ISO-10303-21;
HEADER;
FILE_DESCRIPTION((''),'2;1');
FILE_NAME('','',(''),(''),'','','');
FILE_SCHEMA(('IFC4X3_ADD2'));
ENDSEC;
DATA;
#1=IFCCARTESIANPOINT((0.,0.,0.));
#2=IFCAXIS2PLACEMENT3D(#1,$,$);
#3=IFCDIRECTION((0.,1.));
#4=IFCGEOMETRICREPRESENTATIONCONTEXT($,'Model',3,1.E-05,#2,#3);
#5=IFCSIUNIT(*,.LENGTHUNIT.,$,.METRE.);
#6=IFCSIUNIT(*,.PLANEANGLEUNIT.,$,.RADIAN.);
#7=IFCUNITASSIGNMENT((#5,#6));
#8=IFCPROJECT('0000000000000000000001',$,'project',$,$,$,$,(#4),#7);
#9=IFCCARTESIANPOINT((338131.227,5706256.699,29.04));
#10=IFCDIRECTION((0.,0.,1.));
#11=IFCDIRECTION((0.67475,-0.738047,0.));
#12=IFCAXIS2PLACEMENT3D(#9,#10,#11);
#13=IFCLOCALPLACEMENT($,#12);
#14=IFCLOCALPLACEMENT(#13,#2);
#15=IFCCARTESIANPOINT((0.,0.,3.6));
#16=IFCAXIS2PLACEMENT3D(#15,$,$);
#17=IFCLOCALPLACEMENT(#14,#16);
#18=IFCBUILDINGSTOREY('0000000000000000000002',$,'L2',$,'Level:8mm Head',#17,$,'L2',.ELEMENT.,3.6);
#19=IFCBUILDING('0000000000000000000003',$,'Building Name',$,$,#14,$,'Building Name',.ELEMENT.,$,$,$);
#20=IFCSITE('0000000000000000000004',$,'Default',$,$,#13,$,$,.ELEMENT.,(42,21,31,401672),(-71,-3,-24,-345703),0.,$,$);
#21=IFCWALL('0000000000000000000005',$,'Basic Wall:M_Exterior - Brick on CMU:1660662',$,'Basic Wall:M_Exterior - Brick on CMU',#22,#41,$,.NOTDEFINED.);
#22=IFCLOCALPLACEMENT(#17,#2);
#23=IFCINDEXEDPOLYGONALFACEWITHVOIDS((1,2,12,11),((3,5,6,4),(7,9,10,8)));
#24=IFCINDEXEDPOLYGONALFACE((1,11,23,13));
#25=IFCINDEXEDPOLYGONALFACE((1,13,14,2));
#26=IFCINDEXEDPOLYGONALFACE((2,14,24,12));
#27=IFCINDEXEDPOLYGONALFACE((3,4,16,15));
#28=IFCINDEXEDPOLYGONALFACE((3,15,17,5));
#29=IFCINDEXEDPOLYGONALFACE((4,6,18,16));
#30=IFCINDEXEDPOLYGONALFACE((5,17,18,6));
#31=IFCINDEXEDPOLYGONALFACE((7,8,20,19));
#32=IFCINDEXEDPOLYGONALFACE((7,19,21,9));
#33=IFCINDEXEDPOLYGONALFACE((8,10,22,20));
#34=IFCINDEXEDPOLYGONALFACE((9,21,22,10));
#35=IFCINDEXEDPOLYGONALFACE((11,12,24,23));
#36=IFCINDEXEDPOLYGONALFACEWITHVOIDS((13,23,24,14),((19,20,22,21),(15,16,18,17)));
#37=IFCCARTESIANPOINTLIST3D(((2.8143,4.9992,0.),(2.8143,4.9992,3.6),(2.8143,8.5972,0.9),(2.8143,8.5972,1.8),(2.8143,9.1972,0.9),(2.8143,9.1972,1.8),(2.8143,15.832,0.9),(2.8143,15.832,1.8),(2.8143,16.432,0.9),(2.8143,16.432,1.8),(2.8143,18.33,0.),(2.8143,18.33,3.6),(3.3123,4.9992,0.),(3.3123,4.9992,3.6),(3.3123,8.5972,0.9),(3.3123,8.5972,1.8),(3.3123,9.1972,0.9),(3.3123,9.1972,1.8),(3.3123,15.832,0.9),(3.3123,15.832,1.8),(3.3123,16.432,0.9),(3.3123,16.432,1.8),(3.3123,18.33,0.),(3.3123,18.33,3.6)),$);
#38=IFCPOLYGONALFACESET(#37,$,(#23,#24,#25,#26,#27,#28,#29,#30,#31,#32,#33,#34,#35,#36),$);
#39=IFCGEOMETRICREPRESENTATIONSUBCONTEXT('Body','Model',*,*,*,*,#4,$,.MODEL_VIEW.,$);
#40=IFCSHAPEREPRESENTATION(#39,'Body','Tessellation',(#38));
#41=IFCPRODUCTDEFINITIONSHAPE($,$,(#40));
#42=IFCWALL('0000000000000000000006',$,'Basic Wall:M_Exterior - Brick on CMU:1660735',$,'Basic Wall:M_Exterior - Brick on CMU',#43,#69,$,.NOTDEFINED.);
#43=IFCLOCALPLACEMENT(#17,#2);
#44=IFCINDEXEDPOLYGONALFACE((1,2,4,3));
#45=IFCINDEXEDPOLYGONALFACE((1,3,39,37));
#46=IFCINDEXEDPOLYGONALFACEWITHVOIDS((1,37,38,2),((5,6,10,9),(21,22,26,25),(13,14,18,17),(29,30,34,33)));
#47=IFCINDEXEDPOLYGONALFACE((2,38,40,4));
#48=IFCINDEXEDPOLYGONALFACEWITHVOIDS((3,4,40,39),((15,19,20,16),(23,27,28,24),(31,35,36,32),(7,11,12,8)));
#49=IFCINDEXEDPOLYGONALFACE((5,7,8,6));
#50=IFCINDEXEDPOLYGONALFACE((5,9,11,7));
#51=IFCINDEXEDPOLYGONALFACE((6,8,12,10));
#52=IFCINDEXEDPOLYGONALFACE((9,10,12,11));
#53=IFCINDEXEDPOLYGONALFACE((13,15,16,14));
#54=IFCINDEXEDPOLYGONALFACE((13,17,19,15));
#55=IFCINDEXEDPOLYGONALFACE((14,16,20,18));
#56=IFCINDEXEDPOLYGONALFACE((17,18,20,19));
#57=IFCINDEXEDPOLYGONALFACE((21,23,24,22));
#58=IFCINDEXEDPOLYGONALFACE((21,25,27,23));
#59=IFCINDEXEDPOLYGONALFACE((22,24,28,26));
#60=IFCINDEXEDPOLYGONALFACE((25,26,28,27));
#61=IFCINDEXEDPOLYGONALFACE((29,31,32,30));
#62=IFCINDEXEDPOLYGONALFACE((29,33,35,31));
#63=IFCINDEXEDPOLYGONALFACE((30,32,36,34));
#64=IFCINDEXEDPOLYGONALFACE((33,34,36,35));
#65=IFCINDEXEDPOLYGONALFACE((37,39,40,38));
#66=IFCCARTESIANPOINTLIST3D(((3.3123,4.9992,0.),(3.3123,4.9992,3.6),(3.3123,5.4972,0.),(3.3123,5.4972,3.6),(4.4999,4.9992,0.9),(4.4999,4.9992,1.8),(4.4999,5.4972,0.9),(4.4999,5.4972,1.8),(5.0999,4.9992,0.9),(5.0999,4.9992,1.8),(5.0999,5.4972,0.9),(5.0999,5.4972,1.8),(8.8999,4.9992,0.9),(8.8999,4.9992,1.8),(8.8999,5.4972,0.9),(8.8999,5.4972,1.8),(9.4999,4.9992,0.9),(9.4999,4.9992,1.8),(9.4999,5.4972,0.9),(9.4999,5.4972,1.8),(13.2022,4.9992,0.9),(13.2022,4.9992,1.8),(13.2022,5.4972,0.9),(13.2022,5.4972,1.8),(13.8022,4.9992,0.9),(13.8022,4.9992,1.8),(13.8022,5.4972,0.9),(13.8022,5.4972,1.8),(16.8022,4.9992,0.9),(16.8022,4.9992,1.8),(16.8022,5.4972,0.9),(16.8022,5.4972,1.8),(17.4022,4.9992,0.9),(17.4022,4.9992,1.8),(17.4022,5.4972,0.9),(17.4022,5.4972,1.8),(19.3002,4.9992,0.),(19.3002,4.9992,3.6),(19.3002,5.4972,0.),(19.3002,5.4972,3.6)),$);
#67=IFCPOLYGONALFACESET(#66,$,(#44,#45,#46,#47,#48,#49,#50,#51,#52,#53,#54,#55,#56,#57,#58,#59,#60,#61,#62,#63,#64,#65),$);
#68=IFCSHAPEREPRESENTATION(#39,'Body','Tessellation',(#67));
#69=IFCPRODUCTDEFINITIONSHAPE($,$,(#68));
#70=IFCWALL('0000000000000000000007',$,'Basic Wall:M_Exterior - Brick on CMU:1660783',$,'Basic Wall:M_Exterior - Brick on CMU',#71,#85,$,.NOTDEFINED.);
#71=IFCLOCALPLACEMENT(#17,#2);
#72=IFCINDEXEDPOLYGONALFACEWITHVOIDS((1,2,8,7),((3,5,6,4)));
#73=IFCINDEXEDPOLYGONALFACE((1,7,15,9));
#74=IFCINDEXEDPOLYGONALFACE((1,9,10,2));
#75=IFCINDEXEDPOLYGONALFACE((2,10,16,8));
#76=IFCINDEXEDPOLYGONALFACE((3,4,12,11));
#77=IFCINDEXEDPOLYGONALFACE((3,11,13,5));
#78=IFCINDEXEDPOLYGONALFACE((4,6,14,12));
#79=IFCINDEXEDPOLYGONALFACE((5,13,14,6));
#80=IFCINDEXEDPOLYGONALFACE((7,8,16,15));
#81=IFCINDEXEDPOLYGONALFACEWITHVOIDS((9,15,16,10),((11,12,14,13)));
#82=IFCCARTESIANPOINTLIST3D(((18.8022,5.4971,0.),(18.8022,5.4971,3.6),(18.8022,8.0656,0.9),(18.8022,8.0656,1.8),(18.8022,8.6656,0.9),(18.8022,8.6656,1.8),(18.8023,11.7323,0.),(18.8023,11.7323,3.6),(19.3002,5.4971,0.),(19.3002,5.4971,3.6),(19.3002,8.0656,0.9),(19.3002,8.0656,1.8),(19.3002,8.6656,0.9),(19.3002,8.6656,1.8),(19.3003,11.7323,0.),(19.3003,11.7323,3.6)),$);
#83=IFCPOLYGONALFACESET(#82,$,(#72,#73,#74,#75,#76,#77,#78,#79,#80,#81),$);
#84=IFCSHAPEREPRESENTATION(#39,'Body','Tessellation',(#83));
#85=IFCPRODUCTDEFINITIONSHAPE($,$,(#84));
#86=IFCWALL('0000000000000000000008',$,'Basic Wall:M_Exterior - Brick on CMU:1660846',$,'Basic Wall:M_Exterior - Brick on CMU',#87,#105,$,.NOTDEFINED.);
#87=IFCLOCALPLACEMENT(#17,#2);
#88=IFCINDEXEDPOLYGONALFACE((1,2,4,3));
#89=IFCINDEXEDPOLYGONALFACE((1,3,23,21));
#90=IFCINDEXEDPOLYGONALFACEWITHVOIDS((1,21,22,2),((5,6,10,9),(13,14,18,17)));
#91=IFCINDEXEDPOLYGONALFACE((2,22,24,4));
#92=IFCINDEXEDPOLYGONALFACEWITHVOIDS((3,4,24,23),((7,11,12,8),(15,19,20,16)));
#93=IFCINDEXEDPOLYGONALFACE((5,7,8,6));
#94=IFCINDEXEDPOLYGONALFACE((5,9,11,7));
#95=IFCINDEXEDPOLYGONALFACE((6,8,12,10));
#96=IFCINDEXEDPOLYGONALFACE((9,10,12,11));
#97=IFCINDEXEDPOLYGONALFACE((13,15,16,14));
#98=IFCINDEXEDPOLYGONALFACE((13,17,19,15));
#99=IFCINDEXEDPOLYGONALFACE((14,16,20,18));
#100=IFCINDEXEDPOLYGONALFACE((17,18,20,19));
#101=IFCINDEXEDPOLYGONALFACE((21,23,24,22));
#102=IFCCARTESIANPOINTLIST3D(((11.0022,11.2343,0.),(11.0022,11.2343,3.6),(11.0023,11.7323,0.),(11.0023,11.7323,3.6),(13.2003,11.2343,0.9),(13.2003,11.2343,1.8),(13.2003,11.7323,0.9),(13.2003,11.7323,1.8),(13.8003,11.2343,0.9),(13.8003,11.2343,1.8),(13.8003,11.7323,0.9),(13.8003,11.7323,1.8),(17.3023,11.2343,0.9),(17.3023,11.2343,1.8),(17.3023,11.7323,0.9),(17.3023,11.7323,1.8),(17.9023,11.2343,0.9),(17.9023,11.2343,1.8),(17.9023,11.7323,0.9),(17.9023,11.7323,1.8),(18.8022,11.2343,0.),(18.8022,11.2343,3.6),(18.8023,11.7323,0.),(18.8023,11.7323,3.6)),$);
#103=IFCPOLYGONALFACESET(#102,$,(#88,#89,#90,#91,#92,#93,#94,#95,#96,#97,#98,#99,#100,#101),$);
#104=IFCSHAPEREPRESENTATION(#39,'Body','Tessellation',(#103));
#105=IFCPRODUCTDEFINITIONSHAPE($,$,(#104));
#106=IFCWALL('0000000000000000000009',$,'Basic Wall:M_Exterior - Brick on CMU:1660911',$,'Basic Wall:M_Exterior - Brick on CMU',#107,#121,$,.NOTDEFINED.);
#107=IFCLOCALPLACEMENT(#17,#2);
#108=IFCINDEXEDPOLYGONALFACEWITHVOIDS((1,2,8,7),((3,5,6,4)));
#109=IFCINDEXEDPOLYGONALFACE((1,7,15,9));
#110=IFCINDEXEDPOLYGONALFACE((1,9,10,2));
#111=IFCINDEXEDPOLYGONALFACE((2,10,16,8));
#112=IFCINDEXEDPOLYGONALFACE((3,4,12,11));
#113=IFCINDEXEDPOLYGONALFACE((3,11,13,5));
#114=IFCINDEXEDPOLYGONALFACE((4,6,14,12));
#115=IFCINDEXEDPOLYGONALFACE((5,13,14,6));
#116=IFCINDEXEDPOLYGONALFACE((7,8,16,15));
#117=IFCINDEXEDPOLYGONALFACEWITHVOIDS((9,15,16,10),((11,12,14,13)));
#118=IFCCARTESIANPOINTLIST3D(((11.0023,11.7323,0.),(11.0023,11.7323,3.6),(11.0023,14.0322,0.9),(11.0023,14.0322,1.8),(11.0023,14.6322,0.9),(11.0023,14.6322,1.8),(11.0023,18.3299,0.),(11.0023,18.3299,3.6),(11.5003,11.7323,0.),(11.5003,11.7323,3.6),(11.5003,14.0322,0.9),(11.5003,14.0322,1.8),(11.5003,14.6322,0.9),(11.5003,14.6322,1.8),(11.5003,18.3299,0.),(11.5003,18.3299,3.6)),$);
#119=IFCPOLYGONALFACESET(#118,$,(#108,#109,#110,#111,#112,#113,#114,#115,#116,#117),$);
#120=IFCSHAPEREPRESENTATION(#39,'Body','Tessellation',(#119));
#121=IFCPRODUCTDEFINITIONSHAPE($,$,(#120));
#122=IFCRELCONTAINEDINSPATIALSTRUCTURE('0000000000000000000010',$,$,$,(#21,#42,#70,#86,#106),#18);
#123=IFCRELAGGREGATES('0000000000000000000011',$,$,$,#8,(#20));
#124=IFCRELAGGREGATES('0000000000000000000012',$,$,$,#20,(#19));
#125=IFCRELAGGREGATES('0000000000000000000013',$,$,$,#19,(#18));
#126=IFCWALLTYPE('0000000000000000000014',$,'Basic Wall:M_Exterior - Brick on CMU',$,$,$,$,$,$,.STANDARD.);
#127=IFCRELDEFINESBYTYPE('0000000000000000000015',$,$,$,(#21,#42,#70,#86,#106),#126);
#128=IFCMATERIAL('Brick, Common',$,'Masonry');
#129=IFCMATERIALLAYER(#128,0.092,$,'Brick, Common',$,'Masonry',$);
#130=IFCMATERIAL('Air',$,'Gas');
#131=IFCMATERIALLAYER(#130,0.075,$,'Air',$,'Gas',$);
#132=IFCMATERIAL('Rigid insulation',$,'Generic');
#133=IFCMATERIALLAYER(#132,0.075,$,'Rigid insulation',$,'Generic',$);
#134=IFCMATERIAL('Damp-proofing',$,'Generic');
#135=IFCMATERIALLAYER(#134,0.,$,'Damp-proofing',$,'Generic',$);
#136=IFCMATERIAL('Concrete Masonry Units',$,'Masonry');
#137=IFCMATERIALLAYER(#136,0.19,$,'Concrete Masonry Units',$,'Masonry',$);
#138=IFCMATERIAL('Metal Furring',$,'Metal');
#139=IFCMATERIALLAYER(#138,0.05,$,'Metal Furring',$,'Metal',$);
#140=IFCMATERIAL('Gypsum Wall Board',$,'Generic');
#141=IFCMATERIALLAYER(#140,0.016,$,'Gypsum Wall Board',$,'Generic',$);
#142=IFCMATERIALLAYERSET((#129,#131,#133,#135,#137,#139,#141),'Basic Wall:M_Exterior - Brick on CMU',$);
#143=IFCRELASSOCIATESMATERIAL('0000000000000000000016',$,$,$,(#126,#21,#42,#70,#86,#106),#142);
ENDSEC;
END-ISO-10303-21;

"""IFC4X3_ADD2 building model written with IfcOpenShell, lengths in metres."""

from ifc_helpers import new_model, si_unit, direction, frame, frame_2d, origin, place, context, subcontext, project, spatial, rectangle, extrude, material, layer, layer_set, type_object, element, save


model = new_model("IFC4X3_ADD2")

# Units and contexts
model_context = context("Model", 3, precision=1e-05, world=origin(), true_north=direction((0.0, 1.0)))
body_context = subcontext(model_context, "Body", "Model", "MODEL_VIEW")
ifc_project = project(units=[si_unit("LENGTHUNIT", "METRE"), si_unit("PLANEANGLEUNIT", "RADIAN")], contexts=[model_context])

# Site, building, storey
site_placement = place(None, frame((338131.227, 5706256.699, 29.04), z_axis=(0.0, 0.0, 1.0), x_axis=(0.67475, -0.738047, 0.0)))
site = spatial("IfcSite", under=ifc_project, at=site_placement, Name="Default", CompositionType="ELEMENT", RefLatitude=(42, 21, 31, 401672), RefLongitude=(-71, -3, -24, -345703), RefElevation=0.0)
building_placement = place(site_placement, origin())
building = spatial("IfcBuilding", under=site, at=building_placement, Name="Building Name", LongName="Building Name", CompositionType="ELEMENT")
storey_placement = place(building_placement, frame((0.0, 0.0, 3.6)))
storey = spatial("IfcBuildingStorey", under=building, at=storey_placement, Name="L2", ObjectType="Level:8mm Head", LongName="L2", CompositionType="ELEMENT", Elevation=3.6)

# Walls, openings
ifc_material_1 = material(Name="Brick, Common", Category="Masonry")
ifc_layer_1 = layer(ifc_material_1, 0.092, Name="Brick, Common", Category="Masonry")
ifc_material_2 = material(Name="Air", Category="Gas")
ifc_layer_2 = layer(ifc_material_2, 0.075, Name="Air", Category="Gas")
ifc_material_3 = material(Name="Rigid insulation", Category="Generic")
ifc_layer_3 = layer(ifc_material_3, 0.075, Name="Rigid insulation", Category="Generic")
ifc_material_4 = material(Name="Damp-proofing", Category="Generic")
ifc_layer_4 = layer(ifc_material_4, 0.0, Name="Damp-proofing", Category="Generic")
ifc_material_5 = material(Name="Concrete Masonry Units", Category="Masonry")
ifc_layer_5 = layer(ifc_material_5, 0.19, Name="Concrete Masonry Units", Category="Masonry")
ifc_material_6 = material(Name="Metal Furring", Category="Metal")
ifc_layer_6 = layer(ifc_material_6, 0.05, Name="Metal Furring", Category="Metal")
ifc_material_7 = material(Name="Gypsum Wall Board", Category="Generic")
ifc_layer_7 = layer(ifc_material_7, 0.016, Name="Gypsum Wall Board", Category="Generic")
ifc_layer_set = layer_set([ifc_layer_1, ifc_layer_2, ifc_layer_3, ifc_layer_4, ifc_layer_5, ifc_layer_6, ifc_layer_7], Name="Basic Wall:M_Exterior - Brick on CMU")
wall_type = type_object("IfcWallType", Name="Basic Wall:M_Exterior - Brick on CMU", PredefinedType="STANDARD", material=ifc_layer_set)
wall_1_placement = place(storey_placement, frame((3.0633, 18.33, 0.0), z_axis=(0.0, 0.0, 1.0), x_axis=(-0.000006, -1.0, 0.0)))
wall_1 = element("IfcWall", 1, at=wall_1_placement, inside=storey, type_object=wall_type, material=ifc_layer_set, Name="Basic Wall:M_Exterior - Brick on CMU:1660662", ObjectType="Basic Wall:M_Exterior - Brick on CMU", PredefinedType="NOTDEFINED", context=body_context, shape_type="SweptSolid", body=[
    extrude(rectangle(XDim=13.3308, YDim=0.498, at=frame_2d((6.6654, 0.0), x_axis=(-1.0, 0.0))), origin(), (0.0, 0.0, 1.0), 3.6),
])
opening_1_placement = place(wall_1_placement, frame((18.33, -3.0631, 0.9)))
element("IfcOpeningElement", 2, at=opening_1_placement, cuts=wall_1, PredefinedType="OPENING", context=body_context, shape_type="SweptSolid", body=[
    extrude(rectangle(XDim=0.9, YDim=0.6, at=frame_2d((0.0, 0.0), x_axis=(0.0, 1.0))), frame((-16.132, 1.7882, 0.45), z_axis=(0.0, 1.0, 0.0), x_axis=(1.0, 0.0, 0.0)), (0.0, 0.0, 1.0), 3.048),
])
opening_2_placement = place(wall_1_placement, frame((18.33, -3.0631, 0.9)))
element("IfcOpeningElement", 3, at=opening_2_placement, cuts=wall_1, PredefinedType="OPENING", context=body_context, shape_type="SweptSolid", body=[
    extrude(rectangle(XDim=0.9, YDim=0.6, at=frame_2d((0.0, 0.0), x_axis=(0.0, 1.0))), frame((-8.8972, 1.7882, 0.45), z_axis=(0.0, 1.0, 0.0), x_axis=(1.0, 0.0, 0.0)), (0.0, 0.0, 1.0), 3.048),
])
wall_2_placement = place(storey_placement, frame((3.3123, 5.2482, 0.0)))
wall_2 = element("IfcWall", 4, at=wall_2_placement, inside=storey, type_object=wall_type, material=ifc_layer_set, Name="Basic Wall:M_Exterior - Brick on CMU:1660735", ObjectType="Basic Wall:M_Exterior - Brick on CMU", PredefinedType="NOTDEFINED", context=body_context, shape_type="SweptSolid", body=[
    extrude(rectangle(XDim=15.988, YDim=0.498, at=frame_2d((7.994, 0.0), x_axis=(-1.0, 0.0))), origin(), (0.0, 0.0, 1.0), 3.6),
])
opening_3_placement = place(wall_2_placement, frame((-3.3122, -5.2482, 0.9)))
element("IfcOpeningElement", 5, at=opening_3_placement, cuts=wall_2, PredefinedType="OPENING", context=body_context, shape_type="SweptSolid", body=[
    extrude(rectangle(XDim=0.9, YDim=0.6, at=frame_2d((0.0, 0.0), x_axis=(0.0, 1.0))), frame((9.1999, 3.9732, 0.45), z_axis=(0.0, 1.0, 0.0), x_axis=(1.0, 0.0, 0.0)), (0.0, 0.0, 1.0), 3.048),
])
opening_4_placement = place(wall_2_placement, frame((-3.3122, -5.2482, 0.9)))
element("IfcOpeningElement", 6, at=opening_4_placement, cuts=wall_2, PredefinedType="OPENING", context=body_context, shape_type="SweptSolid", body=[
    extrude(rectangle(XDim=0.9, YDim=0.6, at=frame_2d((0.0, 0.0), x_axis=(0.0, 1.0))), frame((4.7999, 3.9732, 0.45), z_axis=(0.0, 1.0, 0.0), x_axis=(1.0, 0.0, 0.0)), (0.0, 0.0, 1.0), 3.048),
])
opening_5_placement = place(wall_2_placement, frame((-3.3122, -5.2482, 0.9)))
element("IfcOpeningElement", 7, at=opening_5_placement, cuts=wall_2, PredefinedType="OPENING", context=body_context, shape_type="SweptSolid", body=[
    extrude(rectangle(XDim=0.9, YDim=0.6, at=frame_2d((0.0, 0.0), x_axis=(0.0, 1.0))), frame((17.1022, 3.9732, 0.45), z_axis=(0.0, 1.0, 0.0), x_axis=(1.0, 0.0, 0.0)), (0.0, 0.0, 1.0), 3.048),
])
opening_6_placement = place(wall_2_placement, frame((-3.3122, -5.2482, 0.9)))
element("IfcOpeningElement", 8, at=opening_6_placement, cuts=wall_2, PredefinedType="OPENING", context=body_context, shape_type="SweptSolid", body=[
    extrude(rectangle(XDim=0.9, YDim=0.6, at=frame_2d((0.0, 0.0), x_axis=(0.0, 1.0))), frame((13.5022, 3.9732, 0.45), z_axis=(0.0, 1.0, 0.0), x_axis=(1.0, 0.0, 0.0)), (0.0, 0.0, 1.0), 3.048),
])

# Wall, opening
wall_3_placement = place(storey_placement, frame((19.0512, 5.4971, 0.0), z_axis=(0.0, 0.0, 1.0), x_axis=(0.000006, 1.0, 0.0)))
wall_3 = element("IfcWall", 9, at=wall_3_placement, inside=storey, type_object=wall_type, material=ifc_layer_set, Name="Basic Wall:M_Exterior - Brick on CMU:1660783", ObjectType="Basic Wall:M_Exterior - Brick on CMU", PredefinedType="NOTDEFINED", context=body_context, shape_type="SweptSolid", body=[
    extrude(rectangle(XDim=6.2351, YDim=0.498, at=frame_2d((3.1176, 0.0), x_axis=(-1.0, 0.0))), origin(), (0.0, 0.0, 1.0), 3.6),
])
opening_7_placement = place(wall_3_placement, frame((-5.4974, 19.0511, 0.9)))
element("IfcOpeningElement", 10, at=opening_7_placement, cuts=wall_3, PredefinedType="OPENING", context=body_context, shape_type="SweptSolid", body=[
    extrude(rectangle(XDim=0.9, YDim=0.6, at=frame_2d((0.0, 0.0), x_axis=(0.0, 1.0))), frame((8.3658, -20.3262, 0.45), z_axis=(0.0, 1.0, 0.0), x_axis=(1.0, 0.0, 0.0)), (0.0, 0.0, 1.0), 3.048),
])

# Wall, openings
wall_4_placement = place(storey_placement, frame((18.8023, 11.4833, 0.0), z_axis=(0.0, 0.0, 1.0), x_axis=(-1.0, 0.000006, 0.0)))
wall_4 = element("IfcWall", 11, at=wall_4_placement, inside=storey, type_object=wall_type, material=ifc_layer_set, Name="Basic Wall:M_Exterior - Brick on CMU:1660846", ObjectType="Basic Wall:M_Exterior - Brick on CMU", PredefinedType="NOTDEFINED", context=body_context, shape_type="SweptSolid", body=[
    extrude(rectangle(XDim=7.8, YDim=0.498, at=frame_2d((3.9, 0.0), x_axis=(-1.0, 0.0))), origin(), (0.0, 0.0, 1.0), 3.6),
])
opening_8_placement = place(wall_4_placement, frame((18.8021, 11.4835, 0.9)))
element("IfcOpeningElement", 12, at=opening_8_placement, cuts=wall_4, PredefinedType="OPENING", context=body_context, shape_type="SweptSolid", body=[
    extrude(rectangle(XDim=0.9, YDim=0.6, at=frame_2d((0.0, 0.0), x_axis=(0.0, 1.0))), frame((-13.5002, -12.7584, 0.45), z_axis=(0.0, 1.0, 0.0), x_axis=(1.0, 0.0, 0.0)), (0.0, 0.0, 1.0), 3.048),
])
opening_9_placement = place(wall_4_placement, frame((18.8021, 11.4835, 0.9)))
element("IfcOpeningElement", 13, at=opening_9_placement, cuts=wall_4, PredefinedType="OPENING", context=body_context, shape_type="SweptSolid", body=[
    extrude(rectangle(XDim=0.9, YDim=0.6, at=frame_2d((0.0, 0.0), x_axis=(0.0, 1.0))), frame((-17.6022, -12.7584, 0.45), z_axis=(0.0, 1.0, 0.0), x_axis=(1.0, 0.0, 0.0)), (0.0, 0.0, 1.0), 3.048),
])

# Wall, opening
wall_5_placement = place(storey_placement, frame((11.2513, 11.7323, 0.0), z_axis=(0.0, 0.0, 1.0), x_axis=(0.000006, 1.0, 0.0)))
wall_5 = element("IfcWall", 14, at=wall_5_placement, inside=storey, type_object=wall_type, material=ifc_layer_set, Name="Basic Wall:M_Exterior - Brick on CMU:1660911", ObjectType="Basic Wall:M_Exterior - Brick on CMU", PredefinedType="NOTDEFINED", context=body_context, shape_type="SweptSolid", body=[
    extrude(rectangle(XDim=6.5976, YDim=0.498, at=frame_2d((3.2988, 0.0), x_axis=(-1.0, 0.0))), origin(), (0.0, 0.0, 1.0), 3.6),
])
opening_10_placement = place(wall_5_placement, frame((-11.7325, 11.2511, 0.9)))
element("IfcOpeningElement", 15, at=opening_10_placement, cuts=wall_5, PredefinedType="OPENING", context=body_context, shape_type="SweptSolid", body=[
    extrude(rectangle(XDim=0.9, YDim=0.6, at=frame_2d((0.0, 0.0), x_axis=(0.0, 1.0))), frame((14.3324, -12.5262, 0.45), z_axis=(0.0, 1.0, 0.0), x_axis=(1.0, 0.0, 0.0)), (0.0, 0.0, 1.0), 3.048),
])

save(model, "model.ifc")
